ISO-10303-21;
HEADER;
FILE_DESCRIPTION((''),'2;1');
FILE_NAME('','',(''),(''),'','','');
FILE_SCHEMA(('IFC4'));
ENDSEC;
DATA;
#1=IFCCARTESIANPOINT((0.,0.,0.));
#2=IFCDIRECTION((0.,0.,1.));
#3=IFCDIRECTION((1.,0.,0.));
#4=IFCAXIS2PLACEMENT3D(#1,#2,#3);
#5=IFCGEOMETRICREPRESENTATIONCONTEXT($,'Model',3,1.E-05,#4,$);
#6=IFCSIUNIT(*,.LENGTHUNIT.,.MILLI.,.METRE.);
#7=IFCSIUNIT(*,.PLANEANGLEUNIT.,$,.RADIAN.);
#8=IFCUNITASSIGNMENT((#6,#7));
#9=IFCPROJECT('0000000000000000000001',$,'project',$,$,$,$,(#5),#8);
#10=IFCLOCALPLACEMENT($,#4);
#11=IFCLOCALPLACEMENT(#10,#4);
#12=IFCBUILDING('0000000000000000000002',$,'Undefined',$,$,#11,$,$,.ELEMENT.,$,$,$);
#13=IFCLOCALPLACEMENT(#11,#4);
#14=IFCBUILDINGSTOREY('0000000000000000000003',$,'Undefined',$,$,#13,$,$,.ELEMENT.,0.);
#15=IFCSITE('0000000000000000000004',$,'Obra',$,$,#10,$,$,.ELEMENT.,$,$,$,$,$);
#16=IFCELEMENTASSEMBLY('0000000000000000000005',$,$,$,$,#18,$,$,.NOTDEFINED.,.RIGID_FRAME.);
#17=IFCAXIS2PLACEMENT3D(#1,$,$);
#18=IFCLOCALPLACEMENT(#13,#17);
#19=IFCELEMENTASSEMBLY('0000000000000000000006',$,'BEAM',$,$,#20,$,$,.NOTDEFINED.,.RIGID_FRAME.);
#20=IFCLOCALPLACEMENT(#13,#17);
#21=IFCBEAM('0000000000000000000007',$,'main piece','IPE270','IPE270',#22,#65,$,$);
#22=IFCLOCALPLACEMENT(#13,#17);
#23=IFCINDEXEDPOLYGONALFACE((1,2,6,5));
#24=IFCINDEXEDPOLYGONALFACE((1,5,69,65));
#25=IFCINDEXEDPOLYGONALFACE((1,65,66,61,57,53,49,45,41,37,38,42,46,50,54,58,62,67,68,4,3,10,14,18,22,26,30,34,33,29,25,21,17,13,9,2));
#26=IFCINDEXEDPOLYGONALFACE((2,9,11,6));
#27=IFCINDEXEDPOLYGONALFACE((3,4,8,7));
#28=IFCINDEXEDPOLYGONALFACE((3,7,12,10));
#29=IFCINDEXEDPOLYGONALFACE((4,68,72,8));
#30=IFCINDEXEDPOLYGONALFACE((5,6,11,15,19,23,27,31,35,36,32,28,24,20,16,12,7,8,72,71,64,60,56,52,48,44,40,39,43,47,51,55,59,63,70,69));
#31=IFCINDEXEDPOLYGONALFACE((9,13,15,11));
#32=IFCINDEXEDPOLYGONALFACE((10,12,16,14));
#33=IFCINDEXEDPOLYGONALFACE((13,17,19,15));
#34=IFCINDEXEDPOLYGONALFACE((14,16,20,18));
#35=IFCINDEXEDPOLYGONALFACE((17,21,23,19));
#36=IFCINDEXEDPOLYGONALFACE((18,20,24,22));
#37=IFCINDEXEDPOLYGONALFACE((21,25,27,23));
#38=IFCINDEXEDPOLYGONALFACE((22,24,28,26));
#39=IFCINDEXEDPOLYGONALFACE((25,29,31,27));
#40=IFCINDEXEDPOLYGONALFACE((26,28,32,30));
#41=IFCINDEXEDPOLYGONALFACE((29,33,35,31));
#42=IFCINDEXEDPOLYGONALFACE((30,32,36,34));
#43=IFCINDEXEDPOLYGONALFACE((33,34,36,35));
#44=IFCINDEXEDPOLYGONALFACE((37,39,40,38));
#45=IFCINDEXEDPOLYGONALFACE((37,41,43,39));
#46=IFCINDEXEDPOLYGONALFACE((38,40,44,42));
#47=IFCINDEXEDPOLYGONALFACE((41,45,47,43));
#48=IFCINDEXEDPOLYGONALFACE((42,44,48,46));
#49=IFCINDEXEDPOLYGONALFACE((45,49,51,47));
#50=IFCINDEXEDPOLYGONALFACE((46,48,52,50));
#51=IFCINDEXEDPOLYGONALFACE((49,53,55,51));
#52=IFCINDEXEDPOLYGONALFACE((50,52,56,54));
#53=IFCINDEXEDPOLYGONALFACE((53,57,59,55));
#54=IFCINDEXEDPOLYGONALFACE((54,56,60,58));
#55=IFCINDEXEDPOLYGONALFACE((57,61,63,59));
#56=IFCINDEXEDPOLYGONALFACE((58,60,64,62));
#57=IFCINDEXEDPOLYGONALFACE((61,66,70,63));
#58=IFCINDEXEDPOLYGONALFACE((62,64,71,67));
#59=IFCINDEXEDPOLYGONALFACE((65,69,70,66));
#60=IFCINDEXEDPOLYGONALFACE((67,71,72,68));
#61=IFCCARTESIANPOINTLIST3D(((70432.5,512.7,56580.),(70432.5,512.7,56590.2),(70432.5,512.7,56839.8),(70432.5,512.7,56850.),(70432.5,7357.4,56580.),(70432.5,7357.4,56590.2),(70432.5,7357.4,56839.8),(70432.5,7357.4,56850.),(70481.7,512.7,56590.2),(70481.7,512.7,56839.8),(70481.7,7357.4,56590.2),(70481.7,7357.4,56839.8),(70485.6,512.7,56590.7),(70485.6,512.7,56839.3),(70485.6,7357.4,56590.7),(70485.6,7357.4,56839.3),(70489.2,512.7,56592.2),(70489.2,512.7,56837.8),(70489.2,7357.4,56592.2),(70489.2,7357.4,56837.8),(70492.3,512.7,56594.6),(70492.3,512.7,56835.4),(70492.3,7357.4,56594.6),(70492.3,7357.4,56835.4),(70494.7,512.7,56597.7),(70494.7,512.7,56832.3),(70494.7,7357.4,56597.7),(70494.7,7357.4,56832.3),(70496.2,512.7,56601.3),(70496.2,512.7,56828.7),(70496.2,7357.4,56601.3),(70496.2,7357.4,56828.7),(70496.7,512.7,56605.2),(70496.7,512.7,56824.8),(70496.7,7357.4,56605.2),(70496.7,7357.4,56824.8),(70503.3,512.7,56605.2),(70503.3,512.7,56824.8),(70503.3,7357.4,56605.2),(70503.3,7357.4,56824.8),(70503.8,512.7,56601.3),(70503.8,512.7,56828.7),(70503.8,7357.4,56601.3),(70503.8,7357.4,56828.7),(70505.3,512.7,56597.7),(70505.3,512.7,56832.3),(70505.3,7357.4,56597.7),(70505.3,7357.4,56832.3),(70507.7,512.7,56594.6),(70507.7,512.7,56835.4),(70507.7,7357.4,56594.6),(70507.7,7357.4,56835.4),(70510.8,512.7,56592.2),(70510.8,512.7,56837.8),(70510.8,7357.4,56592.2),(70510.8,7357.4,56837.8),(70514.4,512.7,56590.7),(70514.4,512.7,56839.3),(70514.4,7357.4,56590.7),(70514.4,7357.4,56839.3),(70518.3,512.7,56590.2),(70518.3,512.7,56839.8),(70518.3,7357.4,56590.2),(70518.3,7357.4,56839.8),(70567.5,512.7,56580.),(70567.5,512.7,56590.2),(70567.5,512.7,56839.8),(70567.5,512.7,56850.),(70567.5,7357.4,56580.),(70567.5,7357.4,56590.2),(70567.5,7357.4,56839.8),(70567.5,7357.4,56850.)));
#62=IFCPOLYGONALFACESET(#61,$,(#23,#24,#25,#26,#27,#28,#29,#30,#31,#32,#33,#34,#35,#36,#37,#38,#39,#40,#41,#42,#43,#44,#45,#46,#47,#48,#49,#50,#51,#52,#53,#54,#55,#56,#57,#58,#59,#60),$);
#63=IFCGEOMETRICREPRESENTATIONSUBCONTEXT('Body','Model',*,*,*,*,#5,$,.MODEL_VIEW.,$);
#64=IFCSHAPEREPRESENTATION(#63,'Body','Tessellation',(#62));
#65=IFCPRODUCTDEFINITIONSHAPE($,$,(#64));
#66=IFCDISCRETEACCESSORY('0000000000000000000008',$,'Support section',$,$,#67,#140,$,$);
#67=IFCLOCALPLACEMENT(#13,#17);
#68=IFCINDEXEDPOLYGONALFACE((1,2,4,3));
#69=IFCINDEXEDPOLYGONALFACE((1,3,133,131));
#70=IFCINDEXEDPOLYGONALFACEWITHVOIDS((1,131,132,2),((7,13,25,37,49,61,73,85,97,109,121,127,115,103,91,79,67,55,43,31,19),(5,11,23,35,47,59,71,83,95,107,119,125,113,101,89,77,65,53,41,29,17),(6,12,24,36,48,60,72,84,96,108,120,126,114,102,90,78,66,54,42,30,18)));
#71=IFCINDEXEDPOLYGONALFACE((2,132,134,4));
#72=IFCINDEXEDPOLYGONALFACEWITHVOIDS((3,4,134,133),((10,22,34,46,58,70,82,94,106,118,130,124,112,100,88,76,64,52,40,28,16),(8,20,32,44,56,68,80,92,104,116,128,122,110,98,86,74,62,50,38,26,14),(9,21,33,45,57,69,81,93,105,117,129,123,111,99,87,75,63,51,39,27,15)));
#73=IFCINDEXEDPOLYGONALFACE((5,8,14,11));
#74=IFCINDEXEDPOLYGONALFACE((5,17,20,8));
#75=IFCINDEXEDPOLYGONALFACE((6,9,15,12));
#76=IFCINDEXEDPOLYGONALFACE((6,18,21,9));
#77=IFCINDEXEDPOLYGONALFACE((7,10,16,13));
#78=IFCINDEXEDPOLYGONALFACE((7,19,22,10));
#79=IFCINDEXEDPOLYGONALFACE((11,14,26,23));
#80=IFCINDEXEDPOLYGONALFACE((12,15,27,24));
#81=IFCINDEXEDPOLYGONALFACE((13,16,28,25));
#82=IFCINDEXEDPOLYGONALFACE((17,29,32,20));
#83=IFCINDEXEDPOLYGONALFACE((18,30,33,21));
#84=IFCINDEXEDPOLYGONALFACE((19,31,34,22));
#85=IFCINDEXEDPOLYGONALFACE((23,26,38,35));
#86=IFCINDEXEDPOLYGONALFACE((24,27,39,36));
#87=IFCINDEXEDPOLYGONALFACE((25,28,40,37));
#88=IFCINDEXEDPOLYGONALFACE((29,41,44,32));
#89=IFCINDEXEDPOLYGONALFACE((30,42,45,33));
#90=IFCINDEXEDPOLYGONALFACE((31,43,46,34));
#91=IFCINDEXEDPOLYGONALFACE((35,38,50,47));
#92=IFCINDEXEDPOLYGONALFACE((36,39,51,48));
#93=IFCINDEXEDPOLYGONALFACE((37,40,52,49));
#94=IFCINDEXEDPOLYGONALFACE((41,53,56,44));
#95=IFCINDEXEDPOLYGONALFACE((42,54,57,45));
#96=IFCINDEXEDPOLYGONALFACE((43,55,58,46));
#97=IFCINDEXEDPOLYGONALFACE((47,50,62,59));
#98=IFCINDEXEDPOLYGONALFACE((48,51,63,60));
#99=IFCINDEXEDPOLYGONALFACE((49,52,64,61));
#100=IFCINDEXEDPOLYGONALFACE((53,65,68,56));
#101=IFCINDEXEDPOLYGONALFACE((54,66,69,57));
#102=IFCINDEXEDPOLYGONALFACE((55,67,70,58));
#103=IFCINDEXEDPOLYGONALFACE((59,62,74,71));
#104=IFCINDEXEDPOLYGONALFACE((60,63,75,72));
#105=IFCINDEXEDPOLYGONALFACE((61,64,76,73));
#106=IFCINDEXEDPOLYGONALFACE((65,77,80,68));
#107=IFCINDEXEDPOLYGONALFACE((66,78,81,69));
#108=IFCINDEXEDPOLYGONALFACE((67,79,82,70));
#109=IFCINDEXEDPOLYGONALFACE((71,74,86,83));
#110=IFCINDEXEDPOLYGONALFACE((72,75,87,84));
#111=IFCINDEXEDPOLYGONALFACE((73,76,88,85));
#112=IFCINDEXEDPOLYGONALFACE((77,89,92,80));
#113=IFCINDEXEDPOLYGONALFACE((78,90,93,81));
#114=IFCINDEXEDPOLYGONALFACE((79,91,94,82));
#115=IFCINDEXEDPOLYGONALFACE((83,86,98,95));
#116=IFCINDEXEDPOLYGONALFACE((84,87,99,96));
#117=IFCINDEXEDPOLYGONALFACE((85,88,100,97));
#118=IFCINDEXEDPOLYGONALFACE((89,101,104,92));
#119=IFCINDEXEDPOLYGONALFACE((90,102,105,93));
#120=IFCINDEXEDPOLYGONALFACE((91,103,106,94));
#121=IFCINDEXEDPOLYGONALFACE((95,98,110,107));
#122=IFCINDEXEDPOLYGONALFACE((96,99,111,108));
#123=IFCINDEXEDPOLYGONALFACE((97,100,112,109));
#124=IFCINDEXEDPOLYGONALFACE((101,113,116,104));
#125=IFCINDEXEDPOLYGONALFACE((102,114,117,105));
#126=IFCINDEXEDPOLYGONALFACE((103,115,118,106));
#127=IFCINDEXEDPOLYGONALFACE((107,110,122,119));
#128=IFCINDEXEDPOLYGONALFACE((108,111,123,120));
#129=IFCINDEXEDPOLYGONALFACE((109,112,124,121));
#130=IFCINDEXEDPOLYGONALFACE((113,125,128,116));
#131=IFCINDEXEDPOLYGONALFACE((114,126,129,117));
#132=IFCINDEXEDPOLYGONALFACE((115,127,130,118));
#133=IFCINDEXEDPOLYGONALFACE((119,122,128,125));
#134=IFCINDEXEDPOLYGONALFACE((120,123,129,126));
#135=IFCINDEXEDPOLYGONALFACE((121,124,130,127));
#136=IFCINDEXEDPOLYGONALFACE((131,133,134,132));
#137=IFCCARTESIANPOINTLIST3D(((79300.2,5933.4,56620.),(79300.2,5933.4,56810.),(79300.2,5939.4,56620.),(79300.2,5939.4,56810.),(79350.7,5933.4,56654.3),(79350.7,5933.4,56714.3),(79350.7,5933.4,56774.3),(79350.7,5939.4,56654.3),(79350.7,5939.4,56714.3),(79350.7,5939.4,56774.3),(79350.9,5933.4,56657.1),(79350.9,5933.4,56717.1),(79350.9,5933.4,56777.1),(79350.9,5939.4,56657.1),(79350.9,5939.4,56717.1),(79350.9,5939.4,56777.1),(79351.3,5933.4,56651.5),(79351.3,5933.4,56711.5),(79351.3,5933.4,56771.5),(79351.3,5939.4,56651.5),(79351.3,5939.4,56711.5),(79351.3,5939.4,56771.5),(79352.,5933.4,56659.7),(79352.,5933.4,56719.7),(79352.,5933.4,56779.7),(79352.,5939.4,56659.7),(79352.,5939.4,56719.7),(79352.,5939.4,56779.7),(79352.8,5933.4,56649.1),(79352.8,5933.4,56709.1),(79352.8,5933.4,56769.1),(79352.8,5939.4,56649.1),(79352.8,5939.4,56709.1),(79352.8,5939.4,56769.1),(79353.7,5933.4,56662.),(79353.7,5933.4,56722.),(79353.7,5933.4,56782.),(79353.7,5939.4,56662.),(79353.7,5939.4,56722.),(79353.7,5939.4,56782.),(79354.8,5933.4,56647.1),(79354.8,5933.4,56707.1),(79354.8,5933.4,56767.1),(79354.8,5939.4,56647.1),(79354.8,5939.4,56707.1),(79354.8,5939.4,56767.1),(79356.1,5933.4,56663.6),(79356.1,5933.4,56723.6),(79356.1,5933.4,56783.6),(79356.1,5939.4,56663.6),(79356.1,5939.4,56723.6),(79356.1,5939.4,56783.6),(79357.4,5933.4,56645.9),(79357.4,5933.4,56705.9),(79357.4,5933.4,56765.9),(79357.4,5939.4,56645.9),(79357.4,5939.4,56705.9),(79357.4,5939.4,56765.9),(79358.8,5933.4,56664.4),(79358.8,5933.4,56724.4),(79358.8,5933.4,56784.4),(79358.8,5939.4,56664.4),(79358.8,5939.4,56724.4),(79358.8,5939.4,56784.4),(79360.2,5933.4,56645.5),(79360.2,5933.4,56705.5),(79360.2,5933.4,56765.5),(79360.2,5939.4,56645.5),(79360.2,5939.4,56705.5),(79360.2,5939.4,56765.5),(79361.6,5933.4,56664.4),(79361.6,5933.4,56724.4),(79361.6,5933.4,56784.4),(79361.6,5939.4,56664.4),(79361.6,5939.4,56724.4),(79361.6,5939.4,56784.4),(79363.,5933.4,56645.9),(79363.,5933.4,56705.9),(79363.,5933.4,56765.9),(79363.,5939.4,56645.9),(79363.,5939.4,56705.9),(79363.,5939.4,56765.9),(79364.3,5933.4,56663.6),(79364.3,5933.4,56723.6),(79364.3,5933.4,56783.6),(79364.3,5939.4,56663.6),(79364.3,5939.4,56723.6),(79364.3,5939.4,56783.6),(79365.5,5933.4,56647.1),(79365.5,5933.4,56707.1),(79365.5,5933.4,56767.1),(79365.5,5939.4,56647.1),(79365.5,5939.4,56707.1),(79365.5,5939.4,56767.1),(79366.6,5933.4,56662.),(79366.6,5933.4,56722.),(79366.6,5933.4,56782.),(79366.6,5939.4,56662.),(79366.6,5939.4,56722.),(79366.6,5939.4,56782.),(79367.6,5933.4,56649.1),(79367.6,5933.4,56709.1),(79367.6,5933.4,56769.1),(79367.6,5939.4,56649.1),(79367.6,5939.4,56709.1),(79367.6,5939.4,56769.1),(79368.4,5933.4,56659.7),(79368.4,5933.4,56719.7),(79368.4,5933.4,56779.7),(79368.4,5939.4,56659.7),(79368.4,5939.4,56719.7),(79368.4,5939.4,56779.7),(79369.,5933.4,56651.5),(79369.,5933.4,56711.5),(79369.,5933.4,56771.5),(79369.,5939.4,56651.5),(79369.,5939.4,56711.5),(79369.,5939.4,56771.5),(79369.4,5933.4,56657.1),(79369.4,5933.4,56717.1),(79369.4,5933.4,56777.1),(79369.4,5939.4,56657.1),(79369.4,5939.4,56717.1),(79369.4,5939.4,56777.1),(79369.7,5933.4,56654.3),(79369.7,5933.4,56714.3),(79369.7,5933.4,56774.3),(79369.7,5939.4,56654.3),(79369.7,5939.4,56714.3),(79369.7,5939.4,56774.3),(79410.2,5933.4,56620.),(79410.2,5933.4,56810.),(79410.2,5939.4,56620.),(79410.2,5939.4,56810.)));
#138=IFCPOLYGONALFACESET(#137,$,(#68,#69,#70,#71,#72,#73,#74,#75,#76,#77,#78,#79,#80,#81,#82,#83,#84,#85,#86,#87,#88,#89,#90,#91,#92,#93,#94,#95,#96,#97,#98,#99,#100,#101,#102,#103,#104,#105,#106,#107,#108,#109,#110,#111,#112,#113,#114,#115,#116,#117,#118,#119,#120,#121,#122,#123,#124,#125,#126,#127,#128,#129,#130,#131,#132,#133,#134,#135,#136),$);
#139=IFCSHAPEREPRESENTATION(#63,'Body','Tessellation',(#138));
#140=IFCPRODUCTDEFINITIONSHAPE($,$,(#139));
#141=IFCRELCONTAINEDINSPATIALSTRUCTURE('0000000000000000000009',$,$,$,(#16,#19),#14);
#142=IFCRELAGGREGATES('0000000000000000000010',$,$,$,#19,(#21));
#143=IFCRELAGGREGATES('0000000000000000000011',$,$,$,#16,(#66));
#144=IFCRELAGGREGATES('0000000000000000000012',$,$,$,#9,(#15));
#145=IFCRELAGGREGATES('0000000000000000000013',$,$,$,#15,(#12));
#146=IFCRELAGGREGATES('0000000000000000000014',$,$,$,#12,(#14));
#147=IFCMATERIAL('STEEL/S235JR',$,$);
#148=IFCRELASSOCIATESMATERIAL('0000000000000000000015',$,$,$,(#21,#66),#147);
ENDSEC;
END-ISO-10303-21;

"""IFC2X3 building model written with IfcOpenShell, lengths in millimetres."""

from ifc_helpers import new_model, si_unit, frame, origin_with_axes, origin_2d_with_axis, place, context, subcontext, project, spatial, rectangle, circle, i_section, extrude, source, transform, mapped, material, element, aggregate, save


model = new_model("IFC2X3")

# Units and contexts
model_context = context("Model", 3, precision=1e-05, world=origin_with_axes())
body_context = subcontext(model_context, "Body", "Model", "MODEL_VIEW")
ifc_project = project(units=[si_unit("LENGTHUNIT", "METRE", prefix="MILLI"), si_unit("PLANEANGLEUNIT", "RADIAN")], contexts=[model_context])

# Site, building, storey
site_placement = place(None, origin_with_axes())
site = spatial("IfcSite", under=ifc_project, at=site_placement, Name="Obra", CompositionType="ELEMENT")
building_placement = place(site_placement, origin_with_axes())
building = spatial("IfcBuilding", under=site, at=building_placement, Name="Undefined", CompositionType="ELEMENT")
storey_placement = place(building_placement, origin_with_axes())
storey = spatial("IfcBuildingStorey", under=building, at=storey_placement, Name="Undefined", CompositionType="ELEMENT", Elevation=0.0)

# Element assembly
assembly_1_placement = place(storey_placement, origin_with_axes())
assembly_1 = element("IfcElementAssembly", 1, at=assembly_1_placement, inside=storey, AssemblyPlace="NOTDEFINED", PredefinedType="RIGID_FRAME")
ifc_material_1 = material(Name="STEEL/S235JR")

# Element assembly, beam
assembly_2_placement = place(storey_placement, origin_with_axes())
assembly_2 = element("IfcElementAssembly", 2, at=assembly_2_placement, inside=storey, Name="BEAM", AssemblyPlace="NOTDEFINED", PredefinedType="RIGID_FRAME")
beam_1_placement = place(assembly_2_placement, frame((70500.0, 512.7, 56715.0), z_axis=(0.0, 0.0, 1.0), x_axis=(0.0, 1.0, 0.0)))
beam_1 = element("IfcBeam", 3, at=beam_1_placement, material=ifc_material_1, Name="main piece", Description="IPE270", ObjectType="IPE270", context=body_context, shape_type="SweptSolid", body=[
    extrude(i_section(OverallWidth=135.0, OverallDepth=270.0, WebThickness=6.6, FlangeThickness=10.2, FilletRadius=15.0, at=origin_2d_with_axis()), frame((6844.7, 0.0, 0.0), z_axis=(-1.0, 0.0, 0.0), x_axis=(0.0, -1.0, 0.0)), (0.0, 0.0, 1.0), 6844.7),
])
aggregate(assembly_2, [beam_1])

# Discrete accessory, opening
discrete_accessory_1_placement = place(assembly_1_placement, frame((79355.2, 5936.4, 56620.0), z_axis=(0.0, 0.0, 1.0), x_axis=(-1.0, 0.0, 0.0)))
discrete_accessory_1 = element("IfcDiscreteAccessory", 4, at=discrete_accessory_1_placement, material=ifc_material_1, Name="Support section", context=body_context, shape_type="SweptSolid", body=[
    extrude(rectangle(XDim=6.0, YDim=110.0, at=origin_2d_with_axis()), frame((0.0, 0.0, 190.0), z_axis=(0.0, 0.0, -1.0), x_axis=(0.0, 1.0, 0.0)), (0.0, 0.0, 1.0), 190.0),
])
shared_shape_1 = source(origin_with_axes(), body_context, "Body", "SweptSolid", [
    extrude(circle(Radius=9.5, at=origin_2d_with_axis()), frame((0.0, -9.2, 0.0), z_axis=(0.0, 1.0, 0.0), x_axis=(1.0, 0.0, 0.0)), (0.0, 0.0, 1.0), 6.2),
])
opening_1_placement = place(assembly_1_placement, frame((79310.2, 5942.5, 56835.0), z_axis=(1.0, 0.0, 0.0), x_axis=(0.0, 0.0, -1.0)))
element("IfcOpeningElement", 5, at=opening_1_placement, cuts=discrete_accessory_1, ObjectType="Opening", context=body_context, shape_type="MappedRepresentation", body=[
    mapped(shared_shape_1, transform((60.0, 0.0, 50.0))),
    mapped(shared_shape_1, transform((120.0, 0.0, 50.0))),
    mapped(shared_shape_1, transform((180.0, 0.0, 50.0))),
])
aggregate(assembly_1, [discrete_accessory_1])

save(model, "model.ifc")
